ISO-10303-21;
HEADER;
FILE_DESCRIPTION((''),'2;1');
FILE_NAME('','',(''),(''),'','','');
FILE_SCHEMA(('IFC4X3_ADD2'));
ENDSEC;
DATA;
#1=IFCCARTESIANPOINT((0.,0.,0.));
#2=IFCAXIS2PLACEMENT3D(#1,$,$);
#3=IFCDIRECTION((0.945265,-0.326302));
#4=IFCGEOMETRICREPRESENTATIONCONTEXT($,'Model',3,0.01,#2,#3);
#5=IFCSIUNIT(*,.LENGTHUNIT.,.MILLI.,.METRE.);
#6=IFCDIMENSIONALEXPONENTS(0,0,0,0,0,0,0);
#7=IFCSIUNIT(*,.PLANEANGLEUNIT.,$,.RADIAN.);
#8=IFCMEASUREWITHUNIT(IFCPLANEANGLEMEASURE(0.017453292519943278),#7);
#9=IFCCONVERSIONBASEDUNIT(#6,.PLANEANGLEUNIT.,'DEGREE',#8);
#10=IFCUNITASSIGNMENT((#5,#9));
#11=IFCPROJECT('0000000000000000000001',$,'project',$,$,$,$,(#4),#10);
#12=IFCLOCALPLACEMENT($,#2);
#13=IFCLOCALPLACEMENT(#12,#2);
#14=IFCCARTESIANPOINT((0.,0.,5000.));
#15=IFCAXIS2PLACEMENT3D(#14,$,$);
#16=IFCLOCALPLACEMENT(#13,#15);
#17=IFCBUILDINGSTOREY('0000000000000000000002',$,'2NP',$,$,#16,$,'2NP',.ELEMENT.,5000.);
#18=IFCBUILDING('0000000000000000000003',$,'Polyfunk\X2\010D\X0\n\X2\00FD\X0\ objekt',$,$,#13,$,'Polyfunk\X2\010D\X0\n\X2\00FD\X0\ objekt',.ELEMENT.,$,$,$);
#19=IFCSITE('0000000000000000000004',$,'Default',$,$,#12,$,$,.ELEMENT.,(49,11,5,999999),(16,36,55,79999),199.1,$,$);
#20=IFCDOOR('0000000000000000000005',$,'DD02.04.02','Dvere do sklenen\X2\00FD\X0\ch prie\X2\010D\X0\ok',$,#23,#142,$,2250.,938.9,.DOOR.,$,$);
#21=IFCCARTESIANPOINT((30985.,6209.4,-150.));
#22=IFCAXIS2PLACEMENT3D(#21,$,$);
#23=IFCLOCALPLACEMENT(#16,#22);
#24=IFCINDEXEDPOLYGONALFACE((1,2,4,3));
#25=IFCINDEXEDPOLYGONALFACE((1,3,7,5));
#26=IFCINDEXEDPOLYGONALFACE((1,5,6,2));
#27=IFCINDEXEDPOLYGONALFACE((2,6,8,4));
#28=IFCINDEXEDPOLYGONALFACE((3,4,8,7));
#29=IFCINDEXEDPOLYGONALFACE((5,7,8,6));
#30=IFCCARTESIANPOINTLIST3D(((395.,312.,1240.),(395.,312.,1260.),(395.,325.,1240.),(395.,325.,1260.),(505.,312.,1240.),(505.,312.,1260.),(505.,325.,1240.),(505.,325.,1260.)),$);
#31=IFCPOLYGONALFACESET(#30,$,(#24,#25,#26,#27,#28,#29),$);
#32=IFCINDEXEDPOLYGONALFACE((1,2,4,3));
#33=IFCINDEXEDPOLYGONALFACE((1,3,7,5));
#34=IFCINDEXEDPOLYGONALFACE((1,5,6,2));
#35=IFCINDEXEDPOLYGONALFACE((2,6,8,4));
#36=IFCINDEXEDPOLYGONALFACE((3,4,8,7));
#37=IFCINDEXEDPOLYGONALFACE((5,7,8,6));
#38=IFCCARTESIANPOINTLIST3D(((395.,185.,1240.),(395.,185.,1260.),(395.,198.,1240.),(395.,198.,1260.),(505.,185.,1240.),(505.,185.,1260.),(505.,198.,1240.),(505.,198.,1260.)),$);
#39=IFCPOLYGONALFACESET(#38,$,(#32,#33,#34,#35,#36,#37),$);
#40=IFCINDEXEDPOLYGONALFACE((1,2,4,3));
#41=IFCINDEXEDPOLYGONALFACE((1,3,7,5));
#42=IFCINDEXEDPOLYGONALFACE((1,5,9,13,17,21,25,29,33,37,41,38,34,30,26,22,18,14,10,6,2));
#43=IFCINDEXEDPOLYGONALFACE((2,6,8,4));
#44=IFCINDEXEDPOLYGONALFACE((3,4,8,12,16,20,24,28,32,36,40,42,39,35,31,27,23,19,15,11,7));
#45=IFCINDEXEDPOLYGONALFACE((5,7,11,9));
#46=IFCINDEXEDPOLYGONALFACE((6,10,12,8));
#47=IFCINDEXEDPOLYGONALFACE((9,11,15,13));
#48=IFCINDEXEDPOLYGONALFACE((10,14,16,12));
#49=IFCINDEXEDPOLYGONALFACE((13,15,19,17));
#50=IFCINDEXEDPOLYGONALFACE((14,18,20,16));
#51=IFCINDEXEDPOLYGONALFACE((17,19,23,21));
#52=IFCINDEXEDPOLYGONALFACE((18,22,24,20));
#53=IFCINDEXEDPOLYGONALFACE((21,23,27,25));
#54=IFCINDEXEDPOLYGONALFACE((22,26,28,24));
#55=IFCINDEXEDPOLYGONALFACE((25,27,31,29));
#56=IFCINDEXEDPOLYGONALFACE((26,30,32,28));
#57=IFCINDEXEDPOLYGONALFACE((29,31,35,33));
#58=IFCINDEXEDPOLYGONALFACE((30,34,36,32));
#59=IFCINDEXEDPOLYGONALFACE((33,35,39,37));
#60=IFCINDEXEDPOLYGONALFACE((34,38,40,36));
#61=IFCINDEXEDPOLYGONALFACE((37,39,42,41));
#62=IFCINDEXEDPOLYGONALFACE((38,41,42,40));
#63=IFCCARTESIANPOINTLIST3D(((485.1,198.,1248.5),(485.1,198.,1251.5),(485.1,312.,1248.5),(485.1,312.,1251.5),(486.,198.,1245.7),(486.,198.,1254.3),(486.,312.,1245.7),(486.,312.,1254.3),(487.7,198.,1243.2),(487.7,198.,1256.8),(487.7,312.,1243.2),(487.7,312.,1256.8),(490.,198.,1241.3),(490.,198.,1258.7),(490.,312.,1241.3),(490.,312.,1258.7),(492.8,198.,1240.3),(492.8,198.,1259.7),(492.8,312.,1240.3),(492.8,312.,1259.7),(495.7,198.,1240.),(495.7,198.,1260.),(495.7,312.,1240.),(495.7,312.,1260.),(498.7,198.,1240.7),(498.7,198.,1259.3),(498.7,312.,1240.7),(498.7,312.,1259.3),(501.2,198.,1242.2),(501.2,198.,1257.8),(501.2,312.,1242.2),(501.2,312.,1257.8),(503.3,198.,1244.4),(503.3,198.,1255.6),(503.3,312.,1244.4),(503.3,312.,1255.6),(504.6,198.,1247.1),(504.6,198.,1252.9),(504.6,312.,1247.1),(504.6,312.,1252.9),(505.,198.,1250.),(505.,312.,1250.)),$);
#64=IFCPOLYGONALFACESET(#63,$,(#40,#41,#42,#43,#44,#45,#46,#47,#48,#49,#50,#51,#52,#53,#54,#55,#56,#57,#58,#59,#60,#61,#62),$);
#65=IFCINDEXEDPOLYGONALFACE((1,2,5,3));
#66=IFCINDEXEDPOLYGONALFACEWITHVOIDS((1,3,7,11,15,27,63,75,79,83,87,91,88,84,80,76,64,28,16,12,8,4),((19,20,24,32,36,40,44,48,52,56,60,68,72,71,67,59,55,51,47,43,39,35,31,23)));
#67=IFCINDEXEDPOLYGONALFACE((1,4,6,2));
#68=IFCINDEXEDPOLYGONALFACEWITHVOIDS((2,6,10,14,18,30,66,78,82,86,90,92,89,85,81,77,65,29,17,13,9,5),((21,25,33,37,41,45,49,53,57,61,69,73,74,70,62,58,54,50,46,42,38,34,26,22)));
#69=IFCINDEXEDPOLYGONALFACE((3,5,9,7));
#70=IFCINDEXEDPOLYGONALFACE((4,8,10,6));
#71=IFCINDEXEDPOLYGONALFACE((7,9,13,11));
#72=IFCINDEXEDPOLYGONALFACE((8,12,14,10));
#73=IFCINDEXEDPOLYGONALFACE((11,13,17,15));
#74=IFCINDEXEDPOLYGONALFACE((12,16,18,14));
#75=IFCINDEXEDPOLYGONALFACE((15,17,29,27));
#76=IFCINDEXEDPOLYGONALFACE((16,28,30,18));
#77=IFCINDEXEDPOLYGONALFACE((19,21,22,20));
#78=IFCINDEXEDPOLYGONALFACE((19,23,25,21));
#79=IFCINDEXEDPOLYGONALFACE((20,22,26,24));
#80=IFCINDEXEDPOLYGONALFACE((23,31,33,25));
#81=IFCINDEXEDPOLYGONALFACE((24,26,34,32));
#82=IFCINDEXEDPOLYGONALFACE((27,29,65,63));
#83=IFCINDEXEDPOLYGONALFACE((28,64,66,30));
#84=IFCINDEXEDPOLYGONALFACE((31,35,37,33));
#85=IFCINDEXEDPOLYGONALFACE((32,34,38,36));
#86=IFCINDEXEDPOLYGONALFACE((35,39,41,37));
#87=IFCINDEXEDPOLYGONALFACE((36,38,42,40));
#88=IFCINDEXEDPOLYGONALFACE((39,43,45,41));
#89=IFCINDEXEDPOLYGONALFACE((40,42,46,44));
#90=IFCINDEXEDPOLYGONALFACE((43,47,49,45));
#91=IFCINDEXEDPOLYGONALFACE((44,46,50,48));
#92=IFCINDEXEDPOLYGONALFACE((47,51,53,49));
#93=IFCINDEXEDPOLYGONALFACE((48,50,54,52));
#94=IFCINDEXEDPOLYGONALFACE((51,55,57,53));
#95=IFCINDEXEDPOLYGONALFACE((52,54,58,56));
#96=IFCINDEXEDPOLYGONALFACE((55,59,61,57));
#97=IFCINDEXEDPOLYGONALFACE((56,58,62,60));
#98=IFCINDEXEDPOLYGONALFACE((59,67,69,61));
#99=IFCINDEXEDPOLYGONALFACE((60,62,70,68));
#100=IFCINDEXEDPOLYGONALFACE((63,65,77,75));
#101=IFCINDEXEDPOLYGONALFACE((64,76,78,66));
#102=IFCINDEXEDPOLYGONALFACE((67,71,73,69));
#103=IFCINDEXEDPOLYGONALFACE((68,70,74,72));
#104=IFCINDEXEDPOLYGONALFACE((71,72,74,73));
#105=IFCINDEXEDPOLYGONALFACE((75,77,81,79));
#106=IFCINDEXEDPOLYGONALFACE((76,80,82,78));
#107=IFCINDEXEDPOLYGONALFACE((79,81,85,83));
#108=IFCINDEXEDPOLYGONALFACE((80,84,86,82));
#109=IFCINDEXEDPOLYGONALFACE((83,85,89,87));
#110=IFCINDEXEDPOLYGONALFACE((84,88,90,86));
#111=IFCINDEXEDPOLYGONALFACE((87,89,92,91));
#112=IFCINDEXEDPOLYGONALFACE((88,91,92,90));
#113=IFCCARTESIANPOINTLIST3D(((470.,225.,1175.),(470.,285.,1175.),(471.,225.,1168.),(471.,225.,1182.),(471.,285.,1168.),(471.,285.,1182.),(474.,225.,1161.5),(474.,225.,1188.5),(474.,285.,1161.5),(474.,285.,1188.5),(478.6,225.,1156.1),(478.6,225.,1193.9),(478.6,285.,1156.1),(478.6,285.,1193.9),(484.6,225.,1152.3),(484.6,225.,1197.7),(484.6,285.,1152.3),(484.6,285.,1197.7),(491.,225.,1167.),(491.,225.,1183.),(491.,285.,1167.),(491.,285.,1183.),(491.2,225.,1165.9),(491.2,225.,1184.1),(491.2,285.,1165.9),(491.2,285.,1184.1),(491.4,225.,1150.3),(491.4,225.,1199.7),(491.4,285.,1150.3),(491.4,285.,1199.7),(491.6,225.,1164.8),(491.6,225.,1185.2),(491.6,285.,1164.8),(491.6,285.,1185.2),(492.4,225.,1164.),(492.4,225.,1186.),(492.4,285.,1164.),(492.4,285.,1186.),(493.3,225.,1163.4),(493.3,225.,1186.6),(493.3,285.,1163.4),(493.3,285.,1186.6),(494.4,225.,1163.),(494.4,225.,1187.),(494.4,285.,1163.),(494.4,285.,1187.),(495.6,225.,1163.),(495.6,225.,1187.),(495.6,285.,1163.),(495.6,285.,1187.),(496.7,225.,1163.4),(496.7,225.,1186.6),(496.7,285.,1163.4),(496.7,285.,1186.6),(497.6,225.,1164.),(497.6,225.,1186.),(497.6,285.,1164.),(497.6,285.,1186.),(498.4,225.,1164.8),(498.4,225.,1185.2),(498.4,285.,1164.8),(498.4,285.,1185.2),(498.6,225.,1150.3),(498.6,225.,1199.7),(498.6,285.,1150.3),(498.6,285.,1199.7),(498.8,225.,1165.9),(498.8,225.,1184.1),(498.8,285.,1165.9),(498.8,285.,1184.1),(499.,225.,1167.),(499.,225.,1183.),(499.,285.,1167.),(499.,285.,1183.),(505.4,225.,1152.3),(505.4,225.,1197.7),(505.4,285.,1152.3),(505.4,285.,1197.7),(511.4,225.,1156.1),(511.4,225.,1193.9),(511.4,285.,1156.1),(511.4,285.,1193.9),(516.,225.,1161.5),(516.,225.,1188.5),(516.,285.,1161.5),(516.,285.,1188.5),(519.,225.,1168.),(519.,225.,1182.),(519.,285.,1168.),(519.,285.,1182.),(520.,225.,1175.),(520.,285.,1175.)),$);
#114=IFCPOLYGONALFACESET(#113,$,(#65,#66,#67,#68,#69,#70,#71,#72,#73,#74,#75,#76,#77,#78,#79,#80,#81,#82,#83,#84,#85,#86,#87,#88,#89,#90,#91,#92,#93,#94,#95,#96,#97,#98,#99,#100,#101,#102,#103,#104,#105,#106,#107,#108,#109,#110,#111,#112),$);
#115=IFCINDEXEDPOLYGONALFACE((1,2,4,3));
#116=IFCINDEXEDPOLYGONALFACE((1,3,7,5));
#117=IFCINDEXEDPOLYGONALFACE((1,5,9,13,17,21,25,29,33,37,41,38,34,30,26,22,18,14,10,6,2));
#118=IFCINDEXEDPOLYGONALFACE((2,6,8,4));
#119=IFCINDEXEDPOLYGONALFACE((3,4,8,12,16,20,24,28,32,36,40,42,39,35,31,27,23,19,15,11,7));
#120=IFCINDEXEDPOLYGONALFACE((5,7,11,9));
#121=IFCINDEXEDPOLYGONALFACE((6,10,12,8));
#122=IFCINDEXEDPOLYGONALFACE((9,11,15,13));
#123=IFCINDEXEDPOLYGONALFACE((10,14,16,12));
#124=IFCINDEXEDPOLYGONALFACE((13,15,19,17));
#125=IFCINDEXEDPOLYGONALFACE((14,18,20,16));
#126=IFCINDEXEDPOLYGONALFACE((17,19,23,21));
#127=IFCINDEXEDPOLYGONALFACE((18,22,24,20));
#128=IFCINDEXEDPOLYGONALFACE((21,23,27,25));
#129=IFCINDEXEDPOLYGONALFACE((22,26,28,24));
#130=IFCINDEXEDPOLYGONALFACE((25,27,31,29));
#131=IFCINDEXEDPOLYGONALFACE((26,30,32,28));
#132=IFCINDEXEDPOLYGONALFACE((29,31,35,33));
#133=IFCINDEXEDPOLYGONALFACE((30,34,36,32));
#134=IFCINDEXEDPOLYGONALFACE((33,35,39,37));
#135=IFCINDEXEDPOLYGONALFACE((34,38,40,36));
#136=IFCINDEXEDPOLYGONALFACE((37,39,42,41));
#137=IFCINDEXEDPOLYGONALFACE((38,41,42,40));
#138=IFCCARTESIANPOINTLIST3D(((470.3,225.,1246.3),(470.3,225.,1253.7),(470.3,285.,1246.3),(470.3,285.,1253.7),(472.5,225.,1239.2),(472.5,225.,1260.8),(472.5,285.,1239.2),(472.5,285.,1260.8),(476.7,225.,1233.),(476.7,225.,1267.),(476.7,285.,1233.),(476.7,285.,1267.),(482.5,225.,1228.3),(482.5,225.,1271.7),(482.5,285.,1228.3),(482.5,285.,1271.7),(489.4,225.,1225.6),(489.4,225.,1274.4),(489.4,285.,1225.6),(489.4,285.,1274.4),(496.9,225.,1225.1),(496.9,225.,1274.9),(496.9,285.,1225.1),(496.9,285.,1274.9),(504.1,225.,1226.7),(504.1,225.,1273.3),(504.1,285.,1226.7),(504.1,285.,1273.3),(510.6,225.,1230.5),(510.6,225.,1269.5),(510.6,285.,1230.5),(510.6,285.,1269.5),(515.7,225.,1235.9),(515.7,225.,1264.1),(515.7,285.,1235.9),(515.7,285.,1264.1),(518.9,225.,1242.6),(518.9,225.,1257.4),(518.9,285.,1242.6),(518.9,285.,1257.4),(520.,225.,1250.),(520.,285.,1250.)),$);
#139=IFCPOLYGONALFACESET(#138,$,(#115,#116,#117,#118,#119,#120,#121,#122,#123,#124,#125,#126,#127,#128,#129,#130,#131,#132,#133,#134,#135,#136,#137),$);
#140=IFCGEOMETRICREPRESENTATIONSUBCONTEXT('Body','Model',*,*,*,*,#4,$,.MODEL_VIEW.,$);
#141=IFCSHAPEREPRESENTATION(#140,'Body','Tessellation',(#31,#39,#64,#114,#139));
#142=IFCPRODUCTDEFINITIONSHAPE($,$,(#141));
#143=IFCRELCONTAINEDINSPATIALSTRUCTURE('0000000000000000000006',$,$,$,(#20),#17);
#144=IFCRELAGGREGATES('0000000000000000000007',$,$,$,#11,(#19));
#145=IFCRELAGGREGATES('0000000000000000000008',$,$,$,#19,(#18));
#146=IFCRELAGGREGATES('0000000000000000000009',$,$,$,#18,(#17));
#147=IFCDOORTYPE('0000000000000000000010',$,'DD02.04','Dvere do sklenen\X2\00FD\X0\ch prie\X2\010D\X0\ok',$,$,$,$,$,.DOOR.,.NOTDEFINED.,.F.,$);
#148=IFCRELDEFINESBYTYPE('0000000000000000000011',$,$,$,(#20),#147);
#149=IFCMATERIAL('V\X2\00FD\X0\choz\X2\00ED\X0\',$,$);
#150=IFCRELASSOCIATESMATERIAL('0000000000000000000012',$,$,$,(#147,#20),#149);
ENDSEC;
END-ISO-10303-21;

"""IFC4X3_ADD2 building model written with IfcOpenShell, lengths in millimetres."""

from ifc_helpers import new_model, entity, si_unit, converted_unit, direction, frame, frame_2d, origin, origin_2d_with_axis, place, context, subcontext, project, spatial, polyline, circle_curve, parameter, trimmed, segment, composite_curve, rectangle, circle, outline, extrude, source, transform, mapped, material, type_object, type_shapes, element, save


model = new_model("IFC4X3_ADD2")

# Units and contexts
model_context = context("Model", 3, precision=0.01, world=origin(), true_north=direction((0.945265, -0.326302)))
body_context = subcontext(model_context, "Body", "Model", "MODEL_VIEW")
ifc_project = project(units=[si_unit("LENGTHUNIT", "METRE", prefix="MILLI"), converted_unit("PLANEANGLEUNIT", "DEGREE", entity("IfcPlaneAngleMeasure", 0.017453292519943278), si_unit("PLANEANGLEUNIT", "RADIAN"), dimensions=[0, 0, 0, 0, 0, 0, 0])], contexts=[model_context])

# Site, building, storey
site_placement = place(None, origin())
site = spatial("IfcSite", under=ifc_project, at=site_placement, Name="Default", CompositionType="ELEMENT", RefLatitude=(49, 11, 5, 999999), RefLongitude=(16, 36, 55, 79999), RefElevation=199.1)
building_placement = place(site_placement, origin())
building = spatial("IfcBuilding", under=site, at=building_placement, Name="Polyfunkčný objekt", LongName="Polyfunkčný objekt", CompositionType="ELEMENT")
storey_placement = place(building_placement, frame((0.0, 0.0, 5000.0)))
storey = spatial("IfcBuildingStorey", under=building, at=storey_placement, Name="2NP", LongName="2NP", CompositionType="ELEMENT", Elevation=5000.0)

# Door
ifc_material_1 = material(Name="Výchozí")
door_type = type_object("IfcDoorType", Name="DD02.04", Description="Dvere do sklenených priečok", OperationType="NOTDEFINED", ParameterTakesPrecedence=False, PredefinedType="DOOR", material=ifc_material_1)
shared_shape_1 = source(origin(), body_context, "Body", "SweptSolid", [
    extrude(rectangle(XDim=13.0, YDim=110.0, at=frame_2d((0.0, 0.0), x_axis=(1.0, 0.0))), frame((450.0, 318.5, 1240.0), z_axis=(0.0, 0.0, 1.0), x_axis=(0.0, 1.0, 0.0)), (0.0, 0.0, 1.0), 20.0),
    extrude(rectangle(XDim=13.0, YDim=110.0, at=frame_2d((0.0, 0.0), x_axis=(1.0, 0.0))), frame((450.0, 191.5, 1240.0), z_axis=(0.0, 0.0, 1.0), x_axis=(0.0, -1.0, 0.0)), (0.0, 0.0, 1.0), 20.0),
    extrude(circle(Radius=10.0, at=origin_2d_with_axis()), frame((495.0, 312.0, 1250.0), z_axis=(0.0, -1.0, 0.0), x_axis=(1.0, 0.0, 0.0)), (0.0, 0.0, 1.0), 114.0),
    extrude(outline(composite_curve([segment(trimmed(circle_curve(origin_2d_with_axis(), 25.0), [parameter(180.0)], [parameter(360.0)], True, "PARAMETER"), True, "CONTINUOUS"), segment(trimmed(circle_curve(origin_2d_with_axis(), 25.0), [parameter(0.0)], [parameter(180.0)], True, "PARAMETER"), True, "CONTINUOUS")], self_intersect=False), holes=[composite_curve([segment(trimmed(circle_curve(frame_2d((0.0, 8.0), x_axis=(1.0, 0.0)), 4.0), [parameter(0.0)], [parameter(180.0)], True, "PARAMETER"), False, "CONTINUOUS"), segment(polyline([(4.0, 8.0), (4.0, -8.0)]), True, "CONTINUOUS"), segment(trimmed(circle_curve(frame_2d((0.0, -8.0), x_axis=(1.0, 0.0)), 4.0), [parameter(180.0)], [parameter(0.0)], True, "PARAMETER"), False, "CONTINUOUS"), segment(polyline([(-4.0, -8.0), (-4.0, 8.0)]), True, "CONTINUOUS")], self_intersect=False)]), frame((495.0, 285.0, 1175.0), z_axis=(0.0, -1.0, 0.0), x_axis=(1.0, 0.0, 0.0)), (0.0, 0.0, 1.0), 60.0),
    extrude(circle(Radius=25.0, at=frame_2d((0.0, 0.0), x_axis=(1.0, 0.0))), frame((495.0, 285.0, 1250.0), z_axis=(0.0, -1.0, 0.0), x_axis=(1.0, 0.0, 0.0)), (0.0, 0.0, 1.0), 60.0),
])
type_shapes(door_type, [shared_shape_1])
door_placement = place(storey_placement, frame((30985.0, 6209.4, -150.0)))
element("IfcDoor", 1, at=door_placement, inside=storey, type_object=door_type, material=ifc_material_1, Name="DD02.04.02", Description="Dvere do sklenených priečok", OverallHeight=2250.0, OverallWidth=938.9, PredefinedType="DOOR", context=body_context, shape_type="MappedRepresentation", body=[
    mapped(shared_shape_1, transform((0.0, 0.0, 0.0), scale=1.0)),
])

save(model, "model.ifc")
